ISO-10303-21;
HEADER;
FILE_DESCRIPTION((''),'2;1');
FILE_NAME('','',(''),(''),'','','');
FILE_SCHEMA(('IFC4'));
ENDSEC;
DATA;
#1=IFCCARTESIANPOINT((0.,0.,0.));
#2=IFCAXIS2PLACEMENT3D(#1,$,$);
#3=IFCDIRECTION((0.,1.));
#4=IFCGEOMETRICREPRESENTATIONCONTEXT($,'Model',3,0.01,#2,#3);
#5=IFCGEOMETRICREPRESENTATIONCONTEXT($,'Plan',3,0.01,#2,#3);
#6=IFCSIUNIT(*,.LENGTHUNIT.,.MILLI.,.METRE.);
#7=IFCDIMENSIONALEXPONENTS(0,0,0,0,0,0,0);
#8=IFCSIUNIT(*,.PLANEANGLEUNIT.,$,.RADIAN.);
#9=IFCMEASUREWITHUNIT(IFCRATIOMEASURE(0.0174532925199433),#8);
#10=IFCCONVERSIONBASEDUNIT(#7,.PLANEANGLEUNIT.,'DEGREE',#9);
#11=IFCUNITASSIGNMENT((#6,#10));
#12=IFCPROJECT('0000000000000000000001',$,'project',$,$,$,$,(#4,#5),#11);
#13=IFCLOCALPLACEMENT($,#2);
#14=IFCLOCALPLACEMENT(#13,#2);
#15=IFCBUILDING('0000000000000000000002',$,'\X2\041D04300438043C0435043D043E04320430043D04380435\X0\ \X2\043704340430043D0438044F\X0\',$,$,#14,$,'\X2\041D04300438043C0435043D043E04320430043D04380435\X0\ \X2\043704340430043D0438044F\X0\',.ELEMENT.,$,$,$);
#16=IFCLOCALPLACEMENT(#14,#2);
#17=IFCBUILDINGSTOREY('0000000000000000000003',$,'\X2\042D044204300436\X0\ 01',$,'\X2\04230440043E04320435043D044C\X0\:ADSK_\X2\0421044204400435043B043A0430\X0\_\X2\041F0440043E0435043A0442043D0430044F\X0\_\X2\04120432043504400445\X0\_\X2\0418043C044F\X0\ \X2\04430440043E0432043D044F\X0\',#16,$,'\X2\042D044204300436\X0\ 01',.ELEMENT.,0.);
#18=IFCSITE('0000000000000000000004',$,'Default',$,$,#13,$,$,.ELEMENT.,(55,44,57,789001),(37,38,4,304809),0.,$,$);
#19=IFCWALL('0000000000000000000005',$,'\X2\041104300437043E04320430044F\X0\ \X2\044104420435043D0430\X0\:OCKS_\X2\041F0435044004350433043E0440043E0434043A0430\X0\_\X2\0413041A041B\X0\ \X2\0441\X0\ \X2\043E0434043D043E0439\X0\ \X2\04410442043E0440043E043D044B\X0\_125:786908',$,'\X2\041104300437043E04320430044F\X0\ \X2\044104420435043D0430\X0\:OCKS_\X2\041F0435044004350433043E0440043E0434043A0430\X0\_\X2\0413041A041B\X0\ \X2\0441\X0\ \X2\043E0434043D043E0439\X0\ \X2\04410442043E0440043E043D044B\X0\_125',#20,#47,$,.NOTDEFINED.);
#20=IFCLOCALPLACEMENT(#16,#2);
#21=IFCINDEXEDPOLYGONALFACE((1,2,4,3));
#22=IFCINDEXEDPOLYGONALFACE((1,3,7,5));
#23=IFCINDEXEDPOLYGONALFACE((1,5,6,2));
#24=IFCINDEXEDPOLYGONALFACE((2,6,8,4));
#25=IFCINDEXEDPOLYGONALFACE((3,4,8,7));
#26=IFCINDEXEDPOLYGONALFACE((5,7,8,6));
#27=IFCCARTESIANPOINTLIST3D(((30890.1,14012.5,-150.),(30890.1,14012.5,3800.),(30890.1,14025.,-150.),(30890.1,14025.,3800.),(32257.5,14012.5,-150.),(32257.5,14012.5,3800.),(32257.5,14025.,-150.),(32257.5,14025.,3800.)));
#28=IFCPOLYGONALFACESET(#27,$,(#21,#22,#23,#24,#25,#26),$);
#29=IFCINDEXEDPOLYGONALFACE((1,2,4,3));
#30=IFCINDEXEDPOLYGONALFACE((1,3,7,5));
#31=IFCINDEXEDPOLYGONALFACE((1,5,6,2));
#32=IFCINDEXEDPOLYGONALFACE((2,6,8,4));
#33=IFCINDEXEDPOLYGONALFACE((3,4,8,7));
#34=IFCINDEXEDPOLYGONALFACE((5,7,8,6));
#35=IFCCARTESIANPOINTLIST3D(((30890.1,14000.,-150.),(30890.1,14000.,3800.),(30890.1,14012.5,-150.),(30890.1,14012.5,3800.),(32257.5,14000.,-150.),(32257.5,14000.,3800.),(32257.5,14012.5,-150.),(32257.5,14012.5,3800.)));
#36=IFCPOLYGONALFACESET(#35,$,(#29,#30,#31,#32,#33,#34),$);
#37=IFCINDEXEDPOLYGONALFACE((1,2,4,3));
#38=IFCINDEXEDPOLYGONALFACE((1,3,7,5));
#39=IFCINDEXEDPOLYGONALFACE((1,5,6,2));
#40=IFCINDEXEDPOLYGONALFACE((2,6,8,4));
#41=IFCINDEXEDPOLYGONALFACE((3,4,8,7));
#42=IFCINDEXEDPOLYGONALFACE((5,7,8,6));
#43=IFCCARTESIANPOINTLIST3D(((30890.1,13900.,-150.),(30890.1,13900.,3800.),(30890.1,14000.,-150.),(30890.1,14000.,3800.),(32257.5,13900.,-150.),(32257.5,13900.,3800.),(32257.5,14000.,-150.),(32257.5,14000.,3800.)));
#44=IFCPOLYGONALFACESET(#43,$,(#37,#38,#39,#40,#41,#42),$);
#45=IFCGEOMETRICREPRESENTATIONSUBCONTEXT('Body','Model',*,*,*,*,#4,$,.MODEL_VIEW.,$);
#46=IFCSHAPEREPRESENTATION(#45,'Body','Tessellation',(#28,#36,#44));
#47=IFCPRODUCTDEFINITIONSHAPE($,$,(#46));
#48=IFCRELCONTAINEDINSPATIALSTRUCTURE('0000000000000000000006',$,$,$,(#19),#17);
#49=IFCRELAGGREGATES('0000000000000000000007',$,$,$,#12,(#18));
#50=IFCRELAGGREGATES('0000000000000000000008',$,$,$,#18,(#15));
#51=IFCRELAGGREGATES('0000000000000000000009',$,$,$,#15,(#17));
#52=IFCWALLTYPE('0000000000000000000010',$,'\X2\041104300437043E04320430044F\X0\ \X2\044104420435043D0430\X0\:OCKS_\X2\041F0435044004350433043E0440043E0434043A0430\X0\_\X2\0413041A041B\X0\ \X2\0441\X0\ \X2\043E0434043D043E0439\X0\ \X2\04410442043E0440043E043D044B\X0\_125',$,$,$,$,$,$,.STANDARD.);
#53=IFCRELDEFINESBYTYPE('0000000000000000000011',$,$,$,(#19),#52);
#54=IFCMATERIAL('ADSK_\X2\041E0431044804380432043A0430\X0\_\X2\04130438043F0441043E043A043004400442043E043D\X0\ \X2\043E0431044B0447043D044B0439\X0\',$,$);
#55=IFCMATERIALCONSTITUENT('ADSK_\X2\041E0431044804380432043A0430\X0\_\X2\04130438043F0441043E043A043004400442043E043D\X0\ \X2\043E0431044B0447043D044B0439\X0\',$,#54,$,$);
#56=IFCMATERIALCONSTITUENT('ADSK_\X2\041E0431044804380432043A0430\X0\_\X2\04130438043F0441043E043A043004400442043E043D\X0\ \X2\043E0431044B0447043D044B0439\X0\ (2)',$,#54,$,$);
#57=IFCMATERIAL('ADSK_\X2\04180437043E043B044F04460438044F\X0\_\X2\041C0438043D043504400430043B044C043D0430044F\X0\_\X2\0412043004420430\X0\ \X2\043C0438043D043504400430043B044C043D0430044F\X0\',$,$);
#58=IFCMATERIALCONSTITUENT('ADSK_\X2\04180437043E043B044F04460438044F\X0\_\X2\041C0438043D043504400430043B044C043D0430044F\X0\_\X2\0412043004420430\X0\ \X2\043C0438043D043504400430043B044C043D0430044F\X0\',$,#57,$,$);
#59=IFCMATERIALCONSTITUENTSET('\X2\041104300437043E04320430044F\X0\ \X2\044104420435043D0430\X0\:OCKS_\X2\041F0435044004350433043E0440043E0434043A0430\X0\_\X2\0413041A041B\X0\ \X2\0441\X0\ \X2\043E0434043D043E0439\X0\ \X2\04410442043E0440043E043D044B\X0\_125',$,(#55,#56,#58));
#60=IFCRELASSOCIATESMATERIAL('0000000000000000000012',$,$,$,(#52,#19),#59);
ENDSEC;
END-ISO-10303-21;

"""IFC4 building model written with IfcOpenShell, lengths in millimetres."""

from ifc_helpers import new_model, entity, si_unit, converted_unit, direction, frame, origin, place, context, subcontext, project, spatial, indexed_curve, outline, extrude, material, constituent, constituent_set, type_object, element, save


model = new_model("IFC4")

# Units and contexts
model_context = context("Model", 3, precision=0.01, world=origin(), true_north=direction((0.0, 1.0)))
plan_context = context("Plan", 3, precision=0.01, world=origin(), true_north=direction((0.0, 1.0)))
body_context = subcontext(model_context, "Body", "Model", "MODEL_VIEW")
ifc_project = project(units=[si_unit("LENGTHUNIT", "METRE", prefix="MILLI"), converted_unit("PLANEANGLEUNIT", "DEGREE", entity("IfcRatioMeasure", 0.0174532925199433), si_unit("PLANEANGLEUNIT", "RADIAN"), dimensions=[0, 0, 0, 0, 0, 0, 0])], contexts=[model_context, plan_context])

# Site, building, storey
site_placement = place(None, frame((0.0, 0.0, 0.0)))
site = spatial("IfcSite", under=ifc_project, at=site_placement, Name="Default", CompositionType="ELEMENT", RefLatitude=(55, 44, 57, 789001), RefLongitude=(37, 38, 4, 304809), RefElevation=0.0)
building_placement = place(site_placement, origin())
building = spatial("IfcBuilding", under=site, at=building_placement, Name="Наименование здания", LongName="Наименование здания", CompositionType="ELEMENT")
storey_placement = place(building_placement, origin())
storey = spatial("IfcBuildingStorey", under=building, at=storey_placement, Name="Этаж 01", ObjectType="Уровень:ADSK_Стрелка_Проектная_Вверх_Имя уровня", LongName="Этаж 01", CompositionType="ELEMENT", Elevation=0.0)

# Shared definitions
ifc_material_1 = material(Name="ADSK_Обшивка_Гипсокартон обычный")
ifc_material_2 = material(Name="ADSK_Изоляция_Минеральная_Вата минеральная")

# Wall
ifc_constituent_1 = constituent(ifc_material_1, Name="ADSK_Обшивка_Гипсокартон обычный")
ifc_constituent_2 = constituent(ifc_material_1, Name="ADSK_Обшивка_Гипсокартон обычный (2)")
ifc_constituent_3 = constituent(ifc_material_2, Name="ADSK_Изоляция_Минеральная_Вата минеральная")
ifc_constituent_set_1 = constituent_set(constituents=[ifc_constituent_1, ifc_constituent_2, ifc_constituent_3], Name="Базовая стена:OCKS_Перегородка_ГКЛ с одной стороны_125")
wall_type_1 = type_object("IfcWallType", Name="Базовая стена:OCKS_Перегородка_ГКЛ с одной стороны_125", PredefinedType="STANDARD", material=ifc_constituent_set_1)
wall_1_placement = place(storey_placement, frame((30890.1, 13962.5, -150.0)))
element("IfcWall", 1, at=wall_1_placement, inside=storey, type_object=wall_type_1, material=ifc_constituent_set_1, Name="Базовая стена:OCKS_Перегородка_ГКЛ с одной стороны_125:786908", ObjectType="Базовая стена:OCKS_Перегородка_ГКЛ с одной стороны_125", PredefinedType="NOTDEFINED", context=body_context, shape_type="SweptSolid", body=[
    extrude(outline(indexed_curve([(-6.3, -683.7), (6.2, -683.7), (6.3, 683.7), (-6.2, 683.7), (-6.3, -683.7)], self_intersect=False)), frame((683.7, 56.3, 0.0), z_axis=(0.0, 0.0, 1.0), x_axis=(0.0, -1.0, 0.0)), (0.0, 0.0, 1.0), 3950.0),
    extrude(outline(indexed_curve([(-683.7, -6.3), (683.7, -6.3), (683.7, 6.2), (-683.7, 6.2), (-683.7, -6.3)], self_intersect=False)), frame((683.7, 43.8, 0.0)), (0.0, 0.0, 1.0), 3950.0),
    extrude(outline(indexed_curve([(-50.0, -683.7), (50.0, -683.7), (50.0, 683.7), (-50.0, 683.7), (-50.0, -683.7)], self_intersect=False)), frame((683.7, -12.5, 0.0), z_axis=(0.0, 0.0, 1.0), x_axis=(0.0, 1.0, 0.0)), (0.0, 0.0, 1.0), 3950.0),
])

save(model, "model.ifc")
